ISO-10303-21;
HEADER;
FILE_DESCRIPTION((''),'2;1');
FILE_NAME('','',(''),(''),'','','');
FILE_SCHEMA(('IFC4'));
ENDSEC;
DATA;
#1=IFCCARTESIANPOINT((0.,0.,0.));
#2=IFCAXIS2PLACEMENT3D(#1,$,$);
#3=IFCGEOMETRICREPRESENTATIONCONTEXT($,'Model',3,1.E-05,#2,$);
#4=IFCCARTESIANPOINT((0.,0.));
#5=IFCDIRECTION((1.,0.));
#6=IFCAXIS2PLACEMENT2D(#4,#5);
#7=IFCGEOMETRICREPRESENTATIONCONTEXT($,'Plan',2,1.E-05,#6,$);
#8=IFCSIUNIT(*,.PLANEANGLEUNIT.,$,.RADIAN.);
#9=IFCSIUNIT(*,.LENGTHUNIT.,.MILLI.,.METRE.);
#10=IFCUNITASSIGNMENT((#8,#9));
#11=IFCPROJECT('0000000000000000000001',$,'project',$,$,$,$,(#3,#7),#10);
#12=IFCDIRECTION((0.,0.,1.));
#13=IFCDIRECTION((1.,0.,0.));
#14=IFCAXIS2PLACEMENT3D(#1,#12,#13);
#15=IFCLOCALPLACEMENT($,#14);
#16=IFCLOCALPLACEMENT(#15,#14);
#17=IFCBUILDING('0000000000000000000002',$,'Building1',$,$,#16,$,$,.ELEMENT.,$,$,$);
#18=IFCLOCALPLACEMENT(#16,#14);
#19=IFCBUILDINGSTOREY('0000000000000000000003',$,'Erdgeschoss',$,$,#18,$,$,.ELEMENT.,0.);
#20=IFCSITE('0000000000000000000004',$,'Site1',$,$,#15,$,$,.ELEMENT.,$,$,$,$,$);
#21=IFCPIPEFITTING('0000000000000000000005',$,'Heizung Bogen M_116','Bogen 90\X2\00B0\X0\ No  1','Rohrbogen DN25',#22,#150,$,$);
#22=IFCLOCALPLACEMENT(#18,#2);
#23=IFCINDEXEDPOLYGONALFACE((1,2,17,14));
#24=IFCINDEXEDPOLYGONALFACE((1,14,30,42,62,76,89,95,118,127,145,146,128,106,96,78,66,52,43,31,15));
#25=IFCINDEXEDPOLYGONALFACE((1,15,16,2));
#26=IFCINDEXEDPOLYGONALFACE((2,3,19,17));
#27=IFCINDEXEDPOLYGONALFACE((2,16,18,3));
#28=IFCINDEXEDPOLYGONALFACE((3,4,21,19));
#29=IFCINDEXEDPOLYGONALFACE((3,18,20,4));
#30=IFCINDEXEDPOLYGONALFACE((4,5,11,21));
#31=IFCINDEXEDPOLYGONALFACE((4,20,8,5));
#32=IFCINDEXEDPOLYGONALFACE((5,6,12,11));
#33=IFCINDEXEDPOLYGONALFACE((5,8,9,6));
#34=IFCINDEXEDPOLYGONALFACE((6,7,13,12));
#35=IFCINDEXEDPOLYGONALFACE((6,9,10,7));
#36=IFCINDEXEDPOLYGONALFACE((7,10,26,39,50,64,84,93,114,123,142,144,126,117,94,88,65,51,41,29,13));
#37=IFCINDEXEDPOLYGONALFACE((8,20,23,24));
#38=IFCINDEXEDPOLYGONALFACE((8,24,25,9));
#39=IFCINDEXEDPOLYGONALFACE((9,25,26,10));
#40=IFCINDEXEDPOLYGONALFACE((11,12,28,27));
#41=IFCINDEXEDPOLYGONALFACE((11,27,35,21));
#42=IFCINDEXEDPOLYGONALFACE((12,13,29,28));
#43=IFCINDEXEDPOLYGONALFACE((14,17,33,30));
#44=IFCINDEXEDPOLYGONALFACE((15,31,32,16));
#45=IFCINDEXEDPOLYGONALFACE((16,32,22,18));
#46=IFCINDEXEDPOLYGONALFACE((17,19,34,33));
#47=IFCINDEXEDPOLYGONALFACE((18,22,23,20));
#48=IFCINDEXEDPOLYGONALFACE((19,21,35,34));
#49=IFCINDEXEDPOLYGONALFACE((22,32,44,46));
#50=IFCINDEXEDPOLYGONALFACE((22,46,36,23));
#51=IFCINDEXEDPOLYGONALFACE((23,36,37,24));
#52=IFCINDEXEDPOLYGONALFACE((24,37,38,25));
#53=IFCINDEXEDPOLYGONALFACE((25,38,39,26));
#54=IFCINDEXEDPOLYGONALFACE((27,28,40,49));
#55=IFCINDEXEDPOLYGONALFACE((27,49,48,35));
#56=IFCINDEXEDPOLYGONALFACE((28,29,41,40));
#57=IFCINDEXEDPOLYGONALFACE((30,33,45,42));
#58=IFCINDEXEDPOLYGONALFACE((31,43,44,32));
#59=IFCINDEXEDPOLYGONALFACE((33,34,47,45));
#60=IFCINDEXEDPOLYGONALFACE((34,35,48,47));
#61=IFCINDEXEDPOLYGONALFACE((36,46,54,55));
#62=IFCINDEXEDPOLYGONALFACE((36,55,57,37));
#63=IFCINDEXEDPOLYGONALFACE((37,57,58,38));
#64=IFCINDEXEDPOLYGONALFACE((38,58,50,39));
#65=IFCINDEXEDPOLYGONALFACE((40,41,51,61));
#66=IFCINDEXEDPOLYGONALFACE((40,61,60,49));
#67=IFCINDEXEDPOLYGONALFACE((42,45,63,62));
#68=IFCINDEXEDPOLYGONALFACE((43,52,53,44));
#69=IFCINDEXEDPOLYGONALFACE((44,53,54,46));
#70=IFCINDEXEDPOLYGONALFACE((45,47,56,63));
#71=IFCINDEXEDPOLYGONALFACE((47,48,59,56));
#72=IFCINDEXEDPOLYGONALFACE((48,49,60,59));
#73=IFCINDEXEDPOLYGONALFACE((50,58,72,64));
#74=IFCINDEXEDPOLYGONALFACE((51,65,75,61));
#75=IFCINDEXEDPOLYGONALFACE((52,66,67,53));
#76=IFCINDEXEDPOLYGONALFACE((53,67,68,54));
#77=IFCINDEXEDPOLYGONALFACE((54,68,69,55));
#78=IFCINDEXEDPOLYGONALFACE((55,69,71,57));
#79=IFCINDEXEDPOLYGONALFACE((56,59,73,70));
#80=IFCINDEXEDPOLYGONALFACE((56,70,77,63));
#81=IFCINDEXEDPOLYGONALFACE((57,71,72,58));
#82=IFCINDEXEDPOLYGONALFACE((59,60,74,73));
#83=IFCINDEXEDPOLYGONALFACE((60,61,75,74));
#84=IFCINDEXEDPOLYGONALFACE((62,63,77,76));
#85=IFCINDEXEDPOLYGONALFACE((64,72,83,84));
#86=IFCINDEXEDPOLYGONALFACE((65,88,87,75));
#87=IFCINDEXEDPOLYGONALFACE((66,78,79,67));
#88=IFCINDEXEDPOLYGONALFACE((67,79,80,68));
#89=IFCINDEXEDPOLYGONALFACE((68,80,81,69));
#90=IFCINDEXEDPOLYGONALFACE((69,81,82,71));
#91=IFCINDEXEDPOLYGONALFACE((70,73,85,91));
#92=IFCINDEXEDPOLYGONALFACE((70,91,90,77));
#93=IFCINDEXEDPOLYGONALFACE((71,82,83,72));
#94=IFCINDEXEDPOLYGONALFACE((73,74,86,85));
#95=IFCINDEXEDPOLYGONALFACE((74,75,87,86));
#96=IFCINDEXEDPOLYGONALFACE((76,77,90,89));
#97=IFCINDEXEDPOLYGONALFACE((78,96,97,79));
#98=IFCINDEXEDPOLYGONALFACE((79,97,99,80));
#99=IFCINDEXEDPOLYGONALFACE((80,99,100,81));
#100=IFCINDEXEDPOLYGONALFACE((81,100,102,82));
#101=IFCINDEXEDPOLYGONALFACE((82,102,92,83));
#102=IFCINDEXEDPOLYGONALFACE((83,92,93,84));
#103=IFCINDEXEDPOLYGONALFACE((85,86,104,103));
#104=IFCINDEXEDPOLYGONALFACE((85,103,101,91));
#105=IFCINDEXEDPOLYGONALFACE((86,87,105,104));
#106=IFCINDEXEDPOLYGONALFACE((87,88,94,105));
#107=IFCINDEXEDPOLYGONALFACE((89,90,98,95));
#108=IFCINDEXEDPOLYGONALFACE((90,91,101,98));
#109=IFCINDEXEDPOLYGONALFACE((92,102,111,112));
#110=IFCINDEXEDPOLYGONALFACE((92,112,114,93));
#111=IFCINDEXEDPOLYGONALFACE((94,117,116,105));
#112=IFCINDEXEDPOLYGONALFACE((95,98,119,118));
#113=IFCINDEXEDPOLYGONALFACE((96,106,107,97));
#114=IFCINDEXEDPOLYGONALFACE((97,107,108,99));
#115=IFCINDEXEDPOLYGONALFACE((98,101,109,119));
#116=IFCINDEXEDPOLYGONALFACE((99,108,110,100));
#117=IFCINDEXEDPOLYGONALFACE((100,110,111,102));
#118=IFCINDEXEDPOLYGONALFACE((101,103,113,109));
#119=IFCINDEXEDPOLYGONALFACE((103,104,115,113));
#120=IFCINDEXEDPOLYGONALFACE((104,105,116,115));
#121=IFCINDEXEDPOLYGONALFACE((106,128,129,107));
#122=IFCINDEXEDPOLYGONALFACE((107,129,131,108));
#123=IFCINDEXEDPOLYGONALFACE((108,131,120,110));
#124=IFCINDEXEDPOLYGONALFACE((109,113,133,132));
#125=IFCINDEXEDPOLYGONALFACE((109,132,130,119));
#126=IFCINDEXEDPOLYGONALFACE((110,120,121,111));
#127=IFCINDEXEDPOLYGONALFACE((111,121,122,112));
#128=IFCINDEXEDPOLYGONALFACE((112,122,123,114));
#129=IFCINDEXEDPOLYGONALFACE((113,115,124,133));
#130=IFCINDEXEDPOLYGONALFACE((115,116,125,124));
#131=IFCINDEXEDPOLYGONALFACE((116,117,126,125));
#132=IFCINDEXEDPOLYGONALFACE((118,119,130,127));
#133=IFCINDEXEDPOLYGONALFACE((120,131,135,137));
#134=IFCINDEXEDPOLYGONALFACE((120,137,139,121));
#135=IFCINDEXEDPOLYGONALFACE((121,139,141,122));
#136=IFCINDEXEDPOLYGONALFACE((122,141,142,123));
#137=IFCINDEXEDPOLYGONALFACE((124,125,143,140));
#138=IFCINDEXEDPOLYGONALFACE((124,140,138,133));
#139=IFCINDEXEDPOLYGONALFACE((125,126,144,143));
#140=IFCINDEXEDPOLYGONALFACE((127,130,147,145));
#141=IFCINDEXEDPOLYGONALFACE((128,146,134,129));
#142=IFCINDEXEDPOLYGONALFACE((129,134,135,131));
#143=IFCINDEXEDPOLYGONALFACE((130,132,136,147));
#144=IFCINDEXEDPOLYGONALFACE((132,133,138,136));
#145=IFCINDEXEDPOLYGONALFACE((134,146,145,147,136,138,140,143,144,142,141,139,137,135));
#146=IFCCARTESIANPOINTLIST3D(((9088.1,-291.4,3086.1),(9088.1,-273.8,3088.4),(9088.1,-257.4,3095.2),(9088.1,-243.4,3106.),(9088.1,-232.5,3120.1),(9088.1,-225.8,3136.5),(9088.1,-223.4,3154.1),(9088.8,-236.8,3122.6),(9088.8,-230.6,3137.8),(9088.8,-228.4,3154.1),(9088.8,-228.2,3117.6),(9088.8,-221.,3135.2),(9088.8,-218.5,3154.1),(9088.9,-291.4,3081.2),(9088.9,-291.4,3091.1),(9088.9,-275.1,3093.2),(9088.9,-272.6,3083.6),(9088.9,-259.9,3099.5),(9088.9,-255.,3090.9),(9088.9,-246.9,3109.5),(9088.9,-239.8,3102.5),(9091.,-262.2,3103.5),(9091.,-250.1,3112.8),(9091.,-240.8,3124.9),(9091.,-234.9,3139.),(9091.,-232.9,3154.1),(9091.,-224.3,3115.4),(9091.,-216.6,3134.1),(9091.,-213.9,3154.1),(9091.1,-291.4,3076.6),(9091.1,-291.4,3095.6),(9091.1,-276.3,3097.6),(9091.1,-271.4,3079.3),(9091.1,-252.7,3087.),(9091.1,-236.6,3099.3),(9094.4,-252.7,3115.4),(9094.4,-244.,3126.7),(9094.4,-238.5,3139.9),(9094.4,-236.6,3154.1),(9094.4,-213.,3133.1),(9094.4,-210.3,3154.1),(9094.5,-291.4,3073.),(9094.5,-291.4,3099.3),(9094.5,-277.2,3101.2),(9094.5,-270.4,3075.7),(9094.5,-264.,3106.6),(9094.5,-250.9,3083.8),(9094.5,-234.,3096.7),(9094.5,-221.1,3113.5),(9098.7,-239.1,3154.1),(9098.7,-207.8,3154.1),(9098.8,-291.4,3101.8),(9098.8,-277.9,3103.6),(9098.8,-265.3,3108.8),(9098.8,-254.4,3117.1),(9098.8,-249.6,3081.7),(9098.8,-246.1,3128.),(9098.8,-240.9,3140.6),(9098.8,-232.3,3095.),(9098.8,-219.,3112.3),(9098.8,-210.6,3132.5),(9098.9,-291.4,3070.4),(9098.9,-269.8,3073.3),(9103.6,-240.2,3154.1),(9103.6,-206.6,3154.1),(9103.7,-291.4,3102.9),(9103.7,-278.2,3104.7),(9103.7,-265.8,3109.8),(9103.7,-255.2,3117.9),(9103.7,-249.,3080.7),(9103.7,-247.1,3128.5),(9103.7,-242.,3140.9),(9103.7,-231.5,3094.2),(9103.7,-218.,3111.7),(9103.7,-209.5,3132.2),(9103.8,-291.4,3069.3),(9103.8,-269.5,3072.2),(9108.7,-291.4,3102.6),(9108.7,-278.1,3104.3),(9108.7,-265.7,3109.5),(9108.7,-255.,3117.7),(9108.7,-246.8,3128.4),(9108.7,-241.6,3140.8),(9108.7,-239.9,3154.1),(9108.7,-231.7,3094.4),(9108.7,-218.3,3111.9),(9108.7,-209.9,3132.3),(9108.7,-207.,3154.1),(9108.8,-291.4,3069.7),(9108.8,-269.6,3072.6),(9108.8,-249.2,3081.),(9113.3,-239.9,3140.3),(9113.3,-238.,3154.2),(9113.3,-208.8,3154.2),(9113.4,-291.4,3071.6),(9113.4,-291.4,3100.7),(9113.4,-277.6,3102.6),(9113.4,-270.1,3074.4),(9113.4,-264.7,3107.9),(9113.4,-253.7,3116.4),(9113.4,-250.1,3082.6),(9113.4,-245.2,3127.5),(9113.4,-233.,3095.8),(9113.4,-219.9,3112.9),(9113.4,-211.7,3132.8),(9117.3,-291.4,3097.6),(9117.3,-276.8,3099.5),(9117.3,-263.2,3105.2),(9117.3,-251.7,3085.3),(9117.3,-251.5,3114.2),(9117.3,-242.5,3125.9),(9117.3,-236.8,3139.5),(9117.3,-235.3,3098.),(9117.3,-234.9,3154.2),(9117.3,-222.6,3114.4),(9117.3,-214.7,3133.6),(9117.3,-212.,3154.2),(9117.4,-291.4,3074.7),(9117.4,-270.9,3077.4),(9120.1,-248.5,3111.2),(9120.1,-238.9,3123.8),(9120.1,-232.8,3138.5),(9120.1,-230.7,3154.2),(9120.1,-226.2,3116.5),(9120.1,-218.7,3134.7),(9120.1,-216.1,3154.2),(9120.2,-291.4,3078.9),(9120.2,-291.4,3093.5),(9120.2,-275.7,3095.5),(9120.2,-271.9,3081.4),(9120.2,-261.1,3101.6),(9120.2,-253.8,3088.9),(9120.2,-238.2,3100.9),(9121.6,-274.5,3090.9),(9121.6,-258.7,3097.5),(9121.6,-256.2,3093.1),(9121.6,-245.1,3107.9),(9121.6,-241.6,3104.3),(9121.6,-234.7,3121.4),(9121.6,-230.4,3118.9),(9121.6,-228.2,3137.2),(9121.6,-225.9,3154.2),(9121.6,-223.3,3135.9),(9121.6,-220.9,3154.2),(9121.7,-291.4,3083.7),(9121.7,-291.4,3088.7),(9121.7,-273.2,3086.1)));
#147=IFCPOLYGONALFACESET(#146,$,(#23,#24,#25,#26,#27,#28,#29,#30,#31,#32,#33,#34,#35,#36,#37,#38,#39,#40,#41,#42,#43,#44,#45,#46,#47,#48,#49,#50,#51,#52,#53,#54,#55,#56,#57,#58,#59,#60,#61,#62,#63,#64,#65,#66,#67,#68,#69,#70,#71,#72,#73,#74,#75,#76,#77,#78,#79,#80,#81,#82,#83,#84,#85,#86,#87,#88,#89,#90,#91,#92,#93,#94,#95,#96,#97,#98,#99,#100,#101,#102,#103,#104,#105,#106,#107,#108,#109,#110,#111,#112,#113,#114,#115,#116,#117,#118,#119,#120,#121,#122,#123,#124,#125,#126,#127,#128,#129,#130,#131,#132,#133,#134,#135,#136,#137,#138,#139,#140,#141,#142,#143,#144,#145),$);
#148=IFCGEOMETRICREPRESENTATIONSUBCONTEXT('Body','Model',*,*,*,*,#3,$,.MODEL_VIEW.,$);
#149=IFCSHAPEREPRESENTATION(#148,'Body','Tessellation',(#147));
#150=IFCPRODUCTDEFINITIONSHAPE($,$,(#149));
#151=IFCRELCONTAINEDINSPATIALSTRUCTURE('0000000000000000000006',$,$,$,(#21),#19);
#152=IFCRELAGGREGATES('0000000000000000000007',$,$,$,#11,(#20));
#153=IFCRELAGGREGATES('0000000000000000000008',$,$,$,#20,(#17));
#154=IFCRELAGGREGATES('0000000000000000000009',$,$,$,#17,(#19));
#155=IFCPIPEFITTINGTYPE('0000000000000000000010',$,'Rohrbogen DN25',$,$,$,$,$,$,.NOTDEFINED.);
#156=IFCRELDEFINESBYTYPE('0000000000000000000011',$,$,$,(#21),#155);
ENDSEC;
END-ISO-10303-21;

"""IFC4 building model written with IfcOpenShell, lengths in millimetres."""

from ifc_helpers import new_model, entity, si_unit, frame, origin, origin_with_axes, origin_2d_with_axis, place, context, subcontext, project, spatial, source, transform, mapped, type_object, element, save


model = new_model("IFC4")

# Units and contexts
model_context = context("Model", 3, precision=1e-05, world=origin())
plan_context = context("Plan", 2, precision=1e-05, world=origin_2d_with_axis())
body_context = subcontext(model_context, "Body", "Model", "MODEL_VIEW")
ifc_project = project(units=[si_unit("PLANEANGLEUNIT", "RADIAN"), si_unit("LENGTHUNIT", "METRE", prefix="MILLI")], contexts=[model_context, plan_context])

# Site, building, storey
site_placement = place(None, origin_with_axes())
site = spatial("IfcSite", under=ifc_project, at=site_placement, Name="Site1", CompositionType="ELEMENT")
building_placement = place(site_placement, origin_with_axes())
building = spatial("IfcBuilding", under=site, at=building_placement, Name="Building1", CompositionType="ELEMENT")
storey_placement = place(building_placement, origin_with_axes())
storey = spatial("IfcBuildingStorey", under=building, at=storey_placement, Name="Erdgeschoss", CompositionType="ELEMENT", Elevation=0.0)

# Pipe fitting
pipe_fitting_type = type_object("IfcPipeFittingType", Name="Rohrbogen DN25", PredefinedType="NOTDEFINED")
shared_shape_1 = source(origin_with_axes(), body_context, "Body", "SolidModel", [
    entity("IfcRevolvedAreaSolid", entity("IfcCircleProfileDef", "AREA", None, entity("IfcAxis2Placement2D", entity("IfcCartesianPoint", [0.0, 0.0]), entity("IfcDirection", [1.0, 0.0])), 16.9), entity("IfcAxis2Placement3D", entity("IfcCartesianPoint", [-42.4, 0.0, 25.6]), entity("IfcDirection", [1.0, 0.0, 0.0]), entity("IfcDirection", [0.0, -0.999999, 0.001364])), entity("IfcAxis1Placement", entity("IfcCartesianPoint", [0.0, 68.0, 0.0]), entity("IfcDirection", [-1.0, 0.0, 0.0])), 1.570796),
])
pipe_fitting_1_placement = place(storey_placement, frame((9105.0, -249.0, 3111.7), z_axis=(0.0, 0.0, 1.0), x_axis=(1.0, 0.0, 0.0)))
element("IfcPipeFitting", 1, at=pipe_fitting_1_placement, inside=storey, type_object=pipe_fitting_type, Name="Heizung Bogen M_116", Description="Bogen 90° No  1", ObjectType="Rohrbogen DN25", context=body_context, shape_type="MappedRepresentation", body=[
    mapped(shared_shape_1, transform((0.0, 0.0, 0.0), x_axis=(0.0, 1.0, 0.0), y_axis=(1.0, 0.0, 0.0), z_axis=(0.0, 0.0, -1.0), scale=1.0)),
])

save(model, "model.ifc")
